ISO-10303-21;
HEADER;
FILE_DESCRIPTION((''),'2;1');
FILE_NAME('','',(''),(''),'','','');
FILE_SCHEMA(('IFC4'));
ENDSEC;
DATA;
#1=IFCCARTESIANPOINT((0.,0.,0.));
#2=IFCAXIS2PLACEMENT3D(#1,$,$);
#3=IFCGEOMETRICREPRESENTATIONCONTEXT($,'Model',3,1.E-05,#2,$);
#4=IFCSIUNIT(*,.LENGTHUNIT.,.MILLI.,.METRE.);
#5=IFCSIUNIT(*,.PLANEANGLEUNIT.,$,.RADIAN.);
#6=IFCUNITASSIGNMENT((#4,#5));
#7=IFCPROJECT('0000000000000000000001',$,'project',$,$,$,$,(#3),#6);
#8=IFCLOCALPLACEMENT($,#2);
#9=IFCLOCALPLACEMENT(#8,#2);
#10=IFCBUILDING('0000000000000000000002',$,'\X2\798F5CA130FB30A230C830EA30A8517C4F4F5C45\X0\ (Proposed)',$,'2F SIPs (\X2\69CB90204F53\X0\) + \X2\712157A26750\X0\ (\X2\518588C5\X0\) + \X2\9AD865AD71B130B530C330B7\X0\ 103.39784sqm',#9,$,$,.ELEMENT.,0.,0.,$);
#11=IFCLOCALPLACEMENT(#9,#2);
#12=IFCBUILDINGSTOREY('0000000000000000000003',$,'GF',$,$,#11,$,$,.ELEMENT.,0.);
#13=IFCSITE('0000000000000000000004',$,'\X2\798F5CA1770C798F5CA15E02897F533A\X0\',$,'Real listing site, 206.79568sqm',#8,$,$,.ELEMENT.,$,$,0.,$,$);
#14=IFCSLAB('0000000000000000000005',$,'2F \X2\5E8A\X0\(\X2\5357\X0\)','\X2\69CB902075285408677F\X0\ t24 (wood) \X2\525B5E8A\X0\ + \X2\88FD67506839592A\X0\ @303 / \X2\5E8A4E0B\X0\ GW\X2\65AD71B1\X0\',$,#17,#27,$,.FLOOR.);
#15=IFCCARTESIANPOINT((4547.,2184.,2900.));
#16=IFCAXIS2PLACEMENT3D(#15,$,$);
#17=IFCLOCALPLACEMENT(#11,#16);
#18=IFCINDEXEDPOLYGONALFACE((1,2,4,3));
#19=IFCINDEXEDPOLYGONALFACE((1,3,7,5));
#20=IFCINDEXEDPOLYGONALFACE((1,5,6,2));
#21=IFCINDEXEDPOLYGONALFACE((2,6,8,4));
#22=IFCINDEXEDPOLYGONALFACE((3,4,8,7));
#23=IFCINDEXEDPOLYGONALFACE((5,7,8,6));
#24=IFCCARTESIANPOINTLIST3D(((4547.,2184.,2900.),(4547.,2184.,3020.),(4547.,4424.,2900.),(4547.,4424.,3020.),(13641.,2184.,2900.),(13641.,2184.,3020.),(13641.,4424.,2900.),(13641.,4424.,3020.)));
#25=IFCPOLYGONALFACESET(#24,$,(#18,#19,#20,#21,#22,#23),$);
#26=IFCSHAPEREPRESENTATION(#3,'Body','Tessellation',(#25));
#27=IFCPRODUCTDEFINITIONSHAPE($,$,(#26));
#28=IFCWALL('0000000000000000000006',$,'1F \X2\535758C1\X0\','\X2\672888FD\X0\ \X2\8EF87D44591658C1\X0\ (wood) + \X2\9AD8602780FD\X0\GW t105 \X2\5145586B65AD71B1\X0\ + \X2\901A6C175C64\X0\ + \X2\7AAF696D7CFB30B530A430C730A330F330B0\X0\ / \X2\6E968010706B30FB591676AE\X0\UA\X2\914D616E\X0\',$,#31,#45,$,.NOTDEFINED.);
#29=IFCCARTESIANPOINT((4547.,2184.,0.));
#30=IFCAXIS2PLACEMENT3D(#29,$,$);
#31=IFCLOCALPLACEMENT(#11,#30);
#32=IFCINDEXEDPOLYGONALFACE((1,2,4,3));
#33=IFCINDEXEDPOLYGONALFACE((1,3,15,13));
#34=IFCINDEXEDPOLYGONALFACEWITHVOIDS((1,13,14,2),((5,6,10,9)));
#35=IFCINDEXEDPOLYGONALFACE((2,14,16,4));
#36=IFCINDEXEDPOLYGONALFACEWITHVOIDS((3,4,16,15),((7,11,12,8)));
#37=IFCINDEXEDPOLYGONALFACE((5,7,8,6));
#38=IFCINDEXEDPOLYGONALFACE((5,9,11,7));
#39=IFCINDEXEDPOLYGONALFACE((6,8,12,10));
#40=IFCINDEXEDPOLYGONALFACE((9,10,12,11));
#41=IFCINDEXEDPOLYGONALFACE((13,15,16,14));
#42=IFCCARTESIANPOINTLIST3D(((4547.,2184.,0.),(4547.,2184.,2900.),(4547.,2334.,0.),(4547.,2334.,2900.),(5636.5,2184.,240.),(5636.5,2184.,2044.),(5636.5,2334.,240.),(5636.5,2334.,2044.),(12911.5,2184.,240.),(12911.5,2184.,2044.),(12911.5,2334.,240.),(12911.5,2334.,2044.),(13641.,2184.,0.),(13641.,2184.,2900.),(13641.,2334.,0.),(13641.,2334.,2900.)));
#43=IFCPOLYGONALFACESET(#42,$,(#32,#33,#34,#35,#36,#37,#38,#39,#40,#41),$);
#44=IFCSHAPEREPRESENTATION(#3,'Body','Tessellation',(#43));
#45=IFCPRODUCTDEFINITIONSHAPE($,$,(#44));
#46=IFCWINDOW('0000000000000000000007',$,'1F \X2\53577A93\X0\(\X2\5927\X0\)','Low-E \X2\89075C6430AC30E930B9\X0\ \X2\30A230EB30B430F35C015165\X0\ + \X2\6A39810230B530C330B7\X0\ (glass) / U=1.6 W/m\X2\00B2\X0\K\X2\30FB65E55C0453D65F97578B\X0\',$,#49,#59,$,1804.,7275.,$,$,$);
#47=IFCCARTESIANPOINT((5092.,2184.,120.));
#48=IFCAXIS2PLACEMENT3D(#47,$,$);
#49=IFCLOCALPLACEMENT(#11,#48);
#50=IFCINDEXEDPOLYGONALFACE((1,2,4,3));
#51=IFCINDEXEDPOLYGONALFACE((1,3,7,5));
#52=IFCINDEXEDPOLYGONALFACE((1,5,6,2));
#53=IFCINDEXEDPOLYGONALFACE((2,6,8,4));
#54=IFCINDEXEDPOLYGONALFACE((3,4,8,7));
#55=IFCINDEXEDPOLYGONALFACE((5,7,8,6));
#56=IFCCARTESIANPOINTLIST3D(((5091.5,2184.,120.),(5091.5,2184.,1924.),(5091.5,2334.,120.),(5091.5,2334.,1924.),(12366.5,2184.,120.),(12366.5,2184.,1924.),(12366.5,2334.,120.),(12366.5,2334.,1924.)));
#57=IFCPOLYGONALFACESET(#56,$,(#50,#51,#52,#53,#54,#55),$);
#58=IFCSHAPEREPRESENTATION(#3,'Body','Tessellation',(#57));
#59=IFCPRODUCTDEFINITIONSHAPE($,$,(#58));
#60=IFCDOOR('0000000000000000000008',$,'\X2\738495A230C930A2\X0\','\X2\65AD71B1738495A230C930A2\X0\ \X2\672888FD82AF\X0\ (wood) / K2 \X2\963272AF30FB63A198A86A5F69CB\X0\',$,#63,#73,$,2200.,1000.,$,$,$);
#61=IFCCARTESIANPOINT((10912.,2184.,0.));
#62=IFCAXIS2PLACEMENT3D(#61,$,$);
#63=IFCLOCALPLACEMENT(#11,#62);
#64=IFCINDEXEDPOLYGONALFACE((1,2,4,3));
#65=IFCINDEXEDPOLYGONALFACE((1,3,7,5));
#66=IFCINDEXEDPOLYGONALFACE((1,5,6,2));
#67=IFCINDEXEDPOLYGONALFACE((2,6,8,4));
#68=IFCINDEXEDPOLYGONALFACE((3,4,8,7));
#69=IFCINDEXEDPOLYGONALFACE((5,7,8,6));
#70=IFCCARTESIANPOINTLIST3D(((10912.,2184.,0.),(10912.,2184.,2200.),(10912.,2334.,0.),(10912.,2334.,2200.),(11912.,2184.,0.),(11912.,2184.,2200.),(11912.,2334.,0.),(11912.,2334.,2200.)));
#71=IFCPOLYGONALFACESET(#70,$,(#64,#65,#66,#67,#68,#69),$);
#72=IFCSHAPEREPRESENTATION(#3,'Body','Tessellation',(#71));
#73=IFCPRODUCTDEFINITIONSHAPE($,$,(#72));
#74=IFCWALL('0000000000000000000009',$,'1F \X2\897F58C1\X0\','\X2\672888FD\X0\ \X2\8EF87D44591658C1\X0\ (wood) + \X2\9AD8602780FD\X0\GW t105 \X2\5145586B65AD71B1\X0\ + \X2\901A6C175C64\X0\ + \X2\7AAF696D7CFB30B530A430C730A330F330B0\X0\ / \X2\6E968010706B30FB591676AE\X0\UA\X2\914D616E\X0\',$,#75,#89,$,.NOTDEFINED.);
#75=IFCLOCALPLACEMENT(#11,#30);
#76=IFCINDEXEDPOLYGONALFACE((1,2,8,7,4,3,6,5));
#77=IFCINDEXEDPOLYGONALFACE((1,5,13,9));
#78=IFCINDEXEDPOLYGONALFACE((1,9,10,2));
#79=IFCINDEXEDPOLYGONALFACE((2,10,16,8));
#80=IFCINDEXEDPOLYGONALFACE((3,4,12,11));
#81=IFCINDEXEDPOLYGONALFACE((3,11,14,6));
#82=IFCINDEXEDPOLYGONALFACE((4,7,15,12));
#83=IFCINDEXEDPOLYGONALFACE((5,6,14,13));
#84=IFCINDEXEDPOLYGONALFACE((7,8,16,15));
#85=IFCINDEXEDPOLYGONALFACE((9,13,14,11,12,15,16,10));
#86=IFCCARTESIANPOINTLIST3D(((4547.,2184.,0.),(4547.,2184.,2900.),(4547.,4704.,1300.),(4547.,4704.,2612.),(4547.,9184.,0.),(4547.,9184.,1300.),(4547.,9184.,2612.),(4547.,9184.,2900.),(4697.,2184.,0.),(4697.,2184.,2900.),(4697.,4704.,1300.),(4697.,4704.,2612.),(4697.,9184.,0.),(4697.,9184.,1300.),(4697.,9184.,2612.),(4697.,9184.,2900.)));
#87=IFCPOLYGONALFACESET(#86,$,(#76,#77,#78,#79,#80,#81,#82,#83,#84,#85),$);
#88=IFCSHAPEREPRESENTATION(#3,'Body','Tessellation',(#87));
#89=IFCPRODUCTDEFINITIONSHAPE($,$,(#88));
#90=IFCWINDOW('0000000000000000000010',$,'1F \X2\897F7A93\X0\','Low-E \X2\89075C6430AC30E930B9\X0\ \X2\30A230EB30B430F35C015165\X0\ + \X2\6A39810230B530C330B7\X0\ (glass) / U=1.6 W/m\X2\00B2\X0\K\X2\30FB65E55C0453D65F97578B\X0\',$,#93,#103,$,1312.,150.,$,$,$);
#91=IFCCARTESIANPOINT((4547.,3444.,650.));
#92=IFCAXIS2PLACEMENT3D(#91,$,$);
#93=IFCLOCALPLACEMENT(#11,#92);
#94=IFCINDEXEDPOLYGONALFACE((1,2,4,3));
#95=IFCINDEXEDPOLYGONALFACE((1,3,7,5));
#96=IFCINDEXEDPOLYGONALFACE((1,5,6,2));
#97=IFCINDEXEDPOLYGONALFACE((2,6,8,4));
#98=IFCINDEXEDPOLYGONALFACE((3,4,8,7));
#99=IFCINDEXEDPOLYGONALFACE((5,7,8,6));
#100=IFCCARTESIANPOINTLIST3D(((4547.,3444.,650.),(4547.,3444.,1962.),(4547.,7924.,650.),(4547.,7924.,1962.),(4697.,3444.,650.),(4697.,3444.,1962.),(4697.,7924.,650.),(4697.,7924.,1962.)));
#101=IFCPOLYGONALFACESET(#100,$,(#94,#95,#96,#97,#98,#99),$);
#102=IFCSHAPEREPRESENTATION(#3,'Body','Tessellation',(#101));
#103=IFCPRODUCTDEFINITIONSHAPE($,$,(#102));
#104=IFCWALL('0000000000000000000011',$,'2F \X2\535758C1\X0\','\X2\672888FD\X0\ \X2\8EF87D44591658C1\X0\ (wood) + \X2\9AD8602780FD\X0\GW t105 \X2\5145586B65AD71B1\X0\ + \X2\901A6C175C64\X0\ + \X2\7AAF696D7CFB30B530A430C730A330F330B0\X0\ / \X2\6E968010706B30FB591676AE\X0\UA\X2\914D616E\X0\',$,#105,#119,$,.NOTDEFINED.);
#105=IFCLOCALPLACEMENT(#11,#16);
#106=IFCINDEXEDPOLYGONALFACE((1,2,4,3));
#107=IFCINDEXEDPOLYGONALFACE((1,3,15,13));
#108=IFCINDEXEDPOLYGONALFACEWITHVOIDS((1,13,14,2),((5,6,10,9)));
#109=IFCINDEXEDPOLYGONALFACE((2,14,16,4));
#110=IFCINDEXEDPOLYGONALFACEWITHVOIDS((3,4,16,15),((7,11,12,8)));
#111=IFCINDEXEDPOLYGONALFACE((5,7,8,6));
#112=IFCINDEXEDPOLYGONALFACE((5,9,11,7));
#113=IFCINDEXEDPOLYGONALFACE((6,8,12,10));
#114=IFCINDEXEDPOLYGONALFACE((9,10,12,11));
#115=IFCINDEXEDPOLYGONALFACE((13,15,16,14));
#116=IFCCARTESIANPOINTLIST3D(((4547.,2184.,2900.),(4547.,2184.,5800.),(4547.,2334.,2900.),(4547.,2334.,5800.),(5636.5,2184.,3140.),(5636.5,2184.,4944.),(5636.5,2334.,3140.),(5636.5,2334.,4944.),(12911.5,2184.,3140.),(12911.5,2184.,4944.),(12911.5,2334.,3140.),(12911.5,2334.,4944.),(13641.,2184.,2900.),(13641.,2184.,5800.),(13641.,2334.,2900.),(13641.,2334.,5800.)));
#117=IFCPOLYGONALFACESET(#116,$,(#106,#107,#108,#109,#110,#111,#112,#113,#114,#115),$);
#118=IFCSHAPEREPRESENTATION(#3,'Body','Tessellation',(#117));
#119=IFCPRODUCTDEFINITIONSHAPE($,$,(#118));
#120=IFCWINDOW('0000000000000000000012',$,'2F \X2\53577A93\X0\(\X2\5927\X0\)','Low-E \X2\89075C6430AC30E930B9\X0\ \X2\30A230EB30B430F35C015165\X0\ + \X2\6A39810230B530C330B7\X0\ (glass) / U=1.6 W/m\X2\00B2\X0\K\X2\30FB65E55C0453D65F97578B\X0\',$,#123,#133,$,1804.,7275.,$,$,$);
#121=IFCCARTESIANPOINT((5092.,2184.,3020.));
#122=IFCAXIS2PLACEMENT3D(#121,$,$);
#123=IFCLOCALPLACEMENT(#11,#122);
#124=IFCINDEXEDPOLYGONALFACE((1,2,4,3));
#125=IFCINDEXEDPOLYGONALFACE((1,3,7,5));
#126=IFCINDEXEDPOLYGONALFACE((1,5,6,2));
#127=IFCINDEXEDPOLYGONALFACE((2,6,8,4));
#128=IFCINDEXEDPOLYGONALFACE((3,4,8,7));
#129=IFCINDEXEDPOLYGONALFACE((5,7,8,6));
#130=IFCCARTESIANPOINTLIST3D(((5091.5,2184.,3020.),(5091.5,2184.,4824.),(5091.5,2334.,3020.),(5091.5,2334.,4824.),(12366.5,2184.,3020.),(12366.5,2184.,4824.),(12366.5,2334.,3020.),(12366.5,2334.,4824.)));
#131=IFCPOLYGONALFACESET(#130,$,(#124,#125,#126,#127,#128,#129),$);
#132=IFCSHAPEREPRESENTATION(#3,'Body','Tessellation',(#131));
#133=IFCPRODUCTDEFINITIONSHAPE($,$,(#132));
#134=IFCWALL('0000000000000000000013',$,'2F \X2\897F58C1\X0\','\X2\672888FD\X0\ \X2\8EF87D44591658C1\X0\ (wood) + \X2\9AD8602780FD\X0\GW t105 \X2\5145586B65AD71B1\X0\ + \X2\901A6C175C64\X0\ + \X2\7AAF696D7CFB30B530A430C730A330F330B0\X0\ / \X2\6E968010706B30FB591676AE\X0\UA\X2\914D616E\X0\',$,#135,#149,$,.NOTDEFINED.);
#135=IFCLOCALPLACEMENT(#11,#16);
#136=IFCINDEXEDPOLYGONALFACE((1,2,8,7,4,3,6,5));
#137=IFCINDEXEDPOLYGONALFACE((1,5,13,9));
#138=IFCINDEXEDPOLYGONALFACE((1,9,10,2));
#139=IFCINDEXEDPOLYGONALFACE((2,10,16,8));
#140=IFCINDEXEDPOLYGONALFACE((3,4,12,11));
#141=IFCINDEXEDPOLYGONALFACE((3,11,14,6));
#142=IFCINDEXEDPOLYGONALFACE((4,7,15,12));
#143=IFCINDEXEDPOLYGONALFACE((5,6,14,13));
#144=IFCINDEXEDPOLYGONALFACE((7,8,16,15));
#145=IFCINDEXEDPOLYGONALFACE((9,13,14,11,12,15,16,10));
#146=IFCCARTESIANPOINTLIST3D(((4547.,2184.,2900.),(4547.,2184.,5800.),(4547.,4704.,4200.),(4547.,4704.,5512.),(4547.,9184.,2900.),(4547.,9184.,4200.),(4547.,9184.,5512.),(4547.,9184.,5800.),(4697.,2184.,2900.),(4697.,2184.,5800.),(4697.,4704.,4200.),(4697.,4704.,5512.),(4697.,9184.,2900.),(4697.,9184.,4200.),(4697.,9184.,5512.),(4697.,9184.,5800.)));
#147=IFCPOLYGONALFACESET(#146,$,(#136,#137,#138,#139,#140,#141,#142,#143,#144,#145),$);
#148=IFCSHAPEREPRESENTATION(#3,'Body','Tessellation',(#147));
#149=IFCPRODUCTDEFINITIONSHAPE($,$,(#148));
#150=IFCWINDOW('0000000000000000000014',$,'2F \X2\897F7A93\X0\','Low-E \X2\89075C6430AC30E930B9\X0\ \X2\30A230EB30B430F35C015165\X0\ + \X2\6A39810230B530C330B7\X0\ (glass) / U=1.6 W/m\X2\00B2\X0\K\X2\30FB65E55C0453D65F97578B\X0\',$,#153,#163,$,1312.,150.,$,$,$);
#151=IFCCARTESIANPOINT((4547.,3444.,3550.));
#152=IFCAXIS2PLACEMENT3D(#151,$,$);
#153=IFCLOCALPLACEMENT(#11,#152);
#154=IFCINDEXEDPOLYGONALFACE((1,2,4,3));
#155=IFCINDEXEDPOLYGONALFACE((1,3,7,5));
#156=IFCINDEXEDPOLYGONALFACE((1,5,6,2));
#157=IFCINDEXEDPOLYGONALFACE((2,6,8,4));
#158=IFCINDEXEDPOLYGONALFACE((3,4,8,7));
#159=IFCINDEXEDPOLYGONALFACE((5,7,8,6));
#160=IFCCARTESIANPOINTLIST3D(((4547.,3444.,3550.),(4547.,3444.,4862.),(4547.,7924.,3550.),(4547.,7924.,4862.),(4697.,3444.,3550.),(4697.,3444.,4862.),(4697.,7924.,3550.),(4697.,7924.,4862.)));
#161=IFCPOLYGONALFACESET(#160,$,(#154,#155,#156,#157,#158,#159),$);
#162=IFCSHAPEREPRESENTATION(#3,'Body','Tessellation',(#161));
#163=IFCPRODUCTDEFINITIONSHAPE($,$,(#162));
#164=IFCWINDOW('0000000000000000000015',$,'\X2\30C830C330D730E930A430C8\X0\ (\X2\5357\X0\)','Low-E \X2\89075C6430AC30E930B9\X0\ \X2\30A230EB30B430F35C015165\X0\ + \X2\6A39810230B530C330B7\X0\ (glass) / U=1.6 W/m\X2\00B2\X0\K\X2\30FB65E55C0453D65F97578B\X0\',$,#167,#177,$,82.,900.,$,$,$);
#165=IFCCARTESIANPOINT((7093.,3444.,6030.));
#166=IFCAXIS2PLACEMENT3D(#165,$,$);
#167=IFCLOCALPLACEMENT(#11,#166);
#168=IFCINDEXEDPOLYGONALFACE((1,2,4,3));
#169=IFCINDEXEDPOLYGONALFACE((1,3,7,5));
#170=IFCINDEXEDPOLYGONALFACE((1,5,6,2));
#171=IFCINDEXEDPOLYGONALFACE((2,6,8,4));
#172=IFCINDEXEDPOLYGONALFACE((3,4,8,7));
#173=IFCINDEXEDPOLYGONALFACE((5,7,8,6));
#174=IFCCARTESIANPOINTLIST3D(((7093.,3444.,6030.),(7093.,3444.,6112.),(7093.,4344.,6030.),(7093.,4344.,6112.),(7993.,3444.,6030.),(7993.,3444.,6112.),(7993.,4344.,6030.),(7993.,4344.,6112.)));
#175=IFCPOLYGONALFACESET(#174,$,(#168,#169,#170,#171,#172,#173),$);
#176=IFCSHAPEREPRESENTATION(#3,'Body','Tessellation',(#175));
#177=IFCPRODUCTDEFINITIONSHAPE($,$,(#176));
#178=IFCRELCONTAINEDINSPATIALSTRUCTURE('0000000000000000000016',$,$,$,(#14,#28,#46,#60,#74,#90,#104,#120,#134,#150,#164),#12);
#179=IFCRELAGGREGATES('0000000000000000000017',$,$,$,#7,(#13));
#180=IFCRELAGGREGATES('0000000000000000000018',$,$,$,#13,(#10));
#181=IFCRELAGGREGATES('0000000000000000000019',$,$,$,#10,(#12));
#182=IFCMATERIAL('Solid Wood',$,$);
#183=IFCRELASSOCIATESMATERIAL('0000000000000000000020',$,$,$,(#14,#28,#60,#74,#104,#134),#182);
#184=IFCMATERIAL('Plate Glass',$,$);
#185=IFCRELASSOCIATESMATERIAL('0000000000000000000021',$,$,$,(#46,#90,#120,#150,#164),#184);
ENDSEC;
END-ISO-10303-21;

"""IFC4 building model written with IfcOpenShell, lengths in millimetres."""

from ifc_helpers import new_model, si_unit, frame, frame_2d, origin, place, context, project, spatial, rectangle, extrude, material, element, fill, save


model = new_model("IFC4")

# Units and contexts
model_context = context("Model", 3, precision=1e-05, world=origin())
ifc_project = project(units=[si_unit("LENGTHUNIT", "METRE", prefix="MILLI"), si_unit("PLANEANGLEUNIT", "RADIAN")], contexts=[model_context])

# Site, building, storey
site_placement = place(None, origin())
site = spatial("IfcSite", under=ifc_project, at=site_placement, Name="福岡県福岡市西区", ObjectType="Real listing site, 206.79568sqm", CompositionType="ELEMENT", RefElevation=0.0)
building_placement = place(site_placement, origin())
building = spatial("IfcBuilding", under=site, at=building_placement, Name="福岡・アトリエ兼住居 (Proposed)", ObjectType="2F SIPs (構造体) + 無垢材 (内装) + 高断熱サッシ 103.39784sqm", CompositionType="ELEMENT", ElevationOfRefHeight=0.0, ElevationOfTerrain=0.0)
storey_placement = place(building_placement, origin())
storey = spatial("IfcBuildingStorey", under=building, at=storey_placement, Name="GF", CompositionType="ELEMENT", Elevation=0.0)

# Slab
ifc_material_1 = material(Name="Solid Wood")
slab_1_placement = place(storey_placement, frame((4547.0, 2184.0, 2900.0)))
element("IfcSlab", 1, at=slab_1_placement, inside=storey, material=ifc_material_1, Name="2F 床(南)", Description="構造用合板 t24 (wood) 剛床 + 製材根太 @303 / 床下 GW断熱", PredefinedType="FLOOR", context=model_context, shape_type="SweptSolid", body=[
    extrude(rectangle(XDim=9094.0, YDim=2240.0, at=frame_2d((4547.0, 1120.0))), frame((4547.0, 2184.0, 2900.0)), (0.0, 0.0, 1.0), 120.0),
])

# Wall, openings, window, door
wall_1_placement = place(storey_placement, frame((4547.0, 2184.0, 0.0)))
wall_1 = element("IfcWall", 2, at=wall_1_placement, inside=storey, material=ifc_material_1, Name="1F 南壁", Description="木製 軸組外壁 (wood) + 高性能GW t105 充填断熱 + 通気層 + 窯業系サイディング / 準耐火・外皮UA配慮", PredefinedType="NOTDEFINED", context=model_context, shape_type="SweptSolid", body=[
    extrude(rectangle(XDim=9094.0, YDim=150.0, at=frame_2d((4547.0, 75.0))), frame((4547.0, 2184.0, 0.0)), (0.0, 0.0, 1.0), 2900.0),
])
opening_1_placement = place(storey_placement, frame((5092.0, 2184.0, 120.0)))
opening_1 = element("IfcOpeningElement", 3, at=opening_1_placement, cuts=wall_1, PredefinedType="NOTDEFINED", context=model_context, shape_type="SweptSolid", body=[
    extrude(rectangle(XDim=7275.0, YDim=150.0, at=frame_2d((3637.0, 75.0))), frame((5092.0, 2184.0, 120.0)), (0.0, 0.0, 1.0), 1804.0),
])
opening_2_placement = place(storey_placement, frame((10912.0, 2184.0, 0.0)))
opening_2 = element("IfcOpeningElement", 4, at=opening_2_placement, cuts=wall_1, PredefinedType="NOTDEFINED", context=model_context, shape_type="SweptSolid", body=[
    extrude(rectangle(XDim=1000.0, YDim=150.0, at=frame_2d((500.0, 75.0))), frame((10912.0, 2184.0, 0.0)), (0.0, 0.0, 1.0), 2200.0),
])
ifc_material_2 = material(Name="Plate Glass")
window_1_placement = place(storey_placement, frame((5092.0, 2184.0, 120.0)))
window_1 = element("IfcWindow", 5, at=window_1_placement, inside=storey, material=ifc_material_2, Name="1F 南窓(大)", Description="Low-E 複層ガラス アルゴン封入 + 樹脂サッシ (glass) / U=1.6 W/m²K・日射取得型", OverallHeight=1804.0, OverallWidth=7275.0, context=model_context, shape_type="SweptSolid", body=[
    extrude(rectangle(XDim=7275.0, YDim=150.0, at=frame_2d((3637.0, 75.0))), frame((5092.0, 2184.0, 120.0)), (0.0, 0.0, 1.0), 1804.0),
])
fill(opening_1, window_1)
door_placement = place(storey_placement, frame((10912.0, 2184.0, 0.0)))
door = element("IfcDoor", 6, at=door_placement, inside=storey, material=ifc_material_1, Name="玄関ドア", Description="断熱玄関ドア 木製芯 (wood) / K2 防犯・採風機構", OverallHeight=2200.0, OverallWidth=1000.0, context=model_context, shape_type="SweptSolid", body=[
    extrude(rectangle(XDim=1000.0, YDim=150.0, at=frame_2d((500.0, 75.0))), frame((10912.0, 2184.0, 0.0)), (0.0, 0.0, 1.0), 2200.0),
])
fill(opening_2, door)

# Walls, openings, windows
wall_2_placement = place(storey_placement, frame((4547.0, 2184.0, 0.0)))
wall_2 = element("IfcWall", 7, at=wall_2_placement, inside=storey, material=ifc_material_1, Name="1F 西壁", Description="木製 軸組外壁 (wood) + 高性能GW t105 充填断熱 + 通気層 + 窯業系サイディング / 準耐火・外皮UA配慮", PredefinedType="NOTDEFINED", context=model_context, shape_type="SweptSolid", body=[
    extrude(rectangle(XDim=150.0, YDim=7000.0, at=frame_2d((75.0, 3500.0))), frame((4547.0, 2184.0, 0.0)), (0.0, 0.0, 1.0), 2900.0),
])
opening_3_placement = place(storey_placement, frame((4547.0, 3444.0, 650.0)))
opening_3 = element("IfcOpeningElement", 8, at=opening_3_placement, cuts=wall_2, PredefinedType="NOTDEFINED", context=model_context, shape_type="SweptSolid", body=[
    extrude(rectangle(XDim=150.0, YDim=4480.0, at=frame_2d((75.0, 2240.0))), frame((4547.0, 3444.0, 650.0)), (0.0, 0.0, 1.0), 1312.0),
])
window_2_placement = place(storey_placement, frame((4547.0, 3444.0, 650.0)))
window_2 = element("IfcWindow", 9, at=window_2_placement, inside=storey, material=ifc_material_2, Name="1F 西窓", Description="Low-E 複層ガラス アルゴン封入 + 樹脂サッシ (glass) / U=1.6 W/m²K・日射取得型", OverallHeight=1312.0, OverallWidth=150.0, context=model_context, shape_type="SweptSolid", body=[
    extrude(rectangle(XDim=150.0, YDim=4480.0, at=frame_2d((75.0, 2240.0))), frame((4547.0, 3444.0, 650.0)), (0.0, 0.0, 1.0), 1312.0),
])
fill(opening_3, window_2)
wall_3_placement = place(storey_placement, frame((4547.0, 2184.0, 2900.0)))
wall_3 = element("IfcWall", 10, at=wall_3_placement, inside=storey, material=ifc_material_1, Name="2F 南壁", Description="木製 軸組外壁 (wood) + 高性能GW t105 充填断熱 + 通気層 + 窯業系サイディング / 準耐火・外皮UA配慮", PredefinedType="NOTDEFINED", context=model_context, shape_type="SweptSolid", body=[
    extrude(rectangle(XDim=9094.0, YDim=150.0, at=frame_2d((4547.0, 75.0))), frame((4547.0, 2184.0, 2900.0)), (0.0, 0.0, 1.0), 2900.0),
])
opening_4_placement = place(storey_placement, frame((5092.0, 2184.0, 3020.0)))
opening_4 = element("IfcOpeningElement", 11, at=opening_4_placement, cuts=wall_3, PredefinedType="NOTDEFINED", context=model_context, shape_type="SweptSolid", body=[
    extrude(rectangle(XDim=7275.0, YDim=150.0, at=frame_2d((3637.0, 75.0))), frame((5092.0, 2184.0, 3020.0)), (0.0, 0.0, 1.0), 1804.0),
])
window_3_placement = place(storey_placement, frame((5092.0, 2184.0, 3020.0)))
window_3 = element("IfcWindow", 12, at=window_3_placement, inside=storey, material=ifc_material_2, Name="2F 南窓(大)", Description="Low-E 複層ガラス アルゴン封入 + 樹脂サッシ (glass) / U=1.6 W/m²K・日射取得型", OverallHeight=1804.0, OverallWidth=7275.0, context=model_context, shape_type="SweptSolid", body=[
    extrude(rectangle(XDim=7275.0, YDim=150.0, at=frame_2d((3637.0, 75.0))), frame((5092.0, 2184.0, 3020.0)), (0.0, 0.0, 1.0), 1804.0),
])
fill(opening_4, window_3)
wall_4_placement = place(storey_placement, frame((4547.0, 2184.0, 2900.0)))
wall_4 = element("IfcWall", 13, at=wall_4_placement, inside=storey, material=ifc_material_1, Name="2F 西壁", Description="木製 軸組外壁 (wood) + 高性能GW t105 充填断熱 + 通気層 + 窯業系サイディング / 準耐火・外皮UA配慮", PredefinedType="NOTDEFINED", context=model_context, shape_type="SweptSolid", body=[
    extrude(rectangle(XDim=150.0, YDim=7000.0, at=frame_2d((75.0, 3500.0))), frame((4547.0, 2184.0, 2900.0)), (0.0, 0.0, 1.0), 2900.0),
])
opening_5_placement = place(storey_placement, frame((4547.0, 3444.0, 3550.0)))
opening_5 = element("IfcOpeningElement", 14, at=opening_5_placement, cuts=wall_4, PredefinedType="NOTDEFINED", context=model_context, shape_type="SweptSolid", body=[
    extrude(rectangle(XDim=150.0, YDim=4480.0, at=frame_2d((75.0, 2240.0))), frame((4547.0, 3444.0, 3550.0)), (0.0, 0.0, 1.0), 1312.0),
])
window_4_placement = place(storey_placement, frame((4547.0, 3444.0, 3550.0)))
window_4 = element("IfcWindow", 15, at=window_4_placement, inside=storey, material=ifc_material_2, Name="2F 西窓", Description="Low-E 複層ガラス アルゴン封入 + 樹脂サッシ (glass) / U=1.6 W/m²K・日射取得型", OverallHeight=1312.0, OverallWidth=150.0, context=model_context, shape_type="SweptSolid", body=[
    extrude(rectangle(XDim=150.0, YDim=4480.0, at=frame_2d((75.0, 2240.0))), frame((4547.0, 3444.0, 3550.0)), (0.0, 0.0, 1.0), 1312.0),
])
fill(opening_5, window_4)

# Window
window_5_placement = place(storey_placement, frame((7093.0, 3444.0, 6030.0)))
element("IfcWindow", 16, at=window_5_placement, inside=storey, material=ifc_material_2, Name="トップライト (南)", Description="Low-E 複層ガラス アルゴン封入 + 樹脂サッシ (glass) / U=1.6 W/m²K・日射取得型", OverallHeight=82.0, OverallWidth=900.0, context=model_context, shape_type="SweptSolid", body=[
    extrude(rectangle(XDim=900.0, YDim=900.0, at=frame_2d((450.0, 450.0))), frame((7093.0, 3444.0, 6030.0)), (0.0, 0.0, 1.0), 82.0),
])

save(model, "model.ifc")
